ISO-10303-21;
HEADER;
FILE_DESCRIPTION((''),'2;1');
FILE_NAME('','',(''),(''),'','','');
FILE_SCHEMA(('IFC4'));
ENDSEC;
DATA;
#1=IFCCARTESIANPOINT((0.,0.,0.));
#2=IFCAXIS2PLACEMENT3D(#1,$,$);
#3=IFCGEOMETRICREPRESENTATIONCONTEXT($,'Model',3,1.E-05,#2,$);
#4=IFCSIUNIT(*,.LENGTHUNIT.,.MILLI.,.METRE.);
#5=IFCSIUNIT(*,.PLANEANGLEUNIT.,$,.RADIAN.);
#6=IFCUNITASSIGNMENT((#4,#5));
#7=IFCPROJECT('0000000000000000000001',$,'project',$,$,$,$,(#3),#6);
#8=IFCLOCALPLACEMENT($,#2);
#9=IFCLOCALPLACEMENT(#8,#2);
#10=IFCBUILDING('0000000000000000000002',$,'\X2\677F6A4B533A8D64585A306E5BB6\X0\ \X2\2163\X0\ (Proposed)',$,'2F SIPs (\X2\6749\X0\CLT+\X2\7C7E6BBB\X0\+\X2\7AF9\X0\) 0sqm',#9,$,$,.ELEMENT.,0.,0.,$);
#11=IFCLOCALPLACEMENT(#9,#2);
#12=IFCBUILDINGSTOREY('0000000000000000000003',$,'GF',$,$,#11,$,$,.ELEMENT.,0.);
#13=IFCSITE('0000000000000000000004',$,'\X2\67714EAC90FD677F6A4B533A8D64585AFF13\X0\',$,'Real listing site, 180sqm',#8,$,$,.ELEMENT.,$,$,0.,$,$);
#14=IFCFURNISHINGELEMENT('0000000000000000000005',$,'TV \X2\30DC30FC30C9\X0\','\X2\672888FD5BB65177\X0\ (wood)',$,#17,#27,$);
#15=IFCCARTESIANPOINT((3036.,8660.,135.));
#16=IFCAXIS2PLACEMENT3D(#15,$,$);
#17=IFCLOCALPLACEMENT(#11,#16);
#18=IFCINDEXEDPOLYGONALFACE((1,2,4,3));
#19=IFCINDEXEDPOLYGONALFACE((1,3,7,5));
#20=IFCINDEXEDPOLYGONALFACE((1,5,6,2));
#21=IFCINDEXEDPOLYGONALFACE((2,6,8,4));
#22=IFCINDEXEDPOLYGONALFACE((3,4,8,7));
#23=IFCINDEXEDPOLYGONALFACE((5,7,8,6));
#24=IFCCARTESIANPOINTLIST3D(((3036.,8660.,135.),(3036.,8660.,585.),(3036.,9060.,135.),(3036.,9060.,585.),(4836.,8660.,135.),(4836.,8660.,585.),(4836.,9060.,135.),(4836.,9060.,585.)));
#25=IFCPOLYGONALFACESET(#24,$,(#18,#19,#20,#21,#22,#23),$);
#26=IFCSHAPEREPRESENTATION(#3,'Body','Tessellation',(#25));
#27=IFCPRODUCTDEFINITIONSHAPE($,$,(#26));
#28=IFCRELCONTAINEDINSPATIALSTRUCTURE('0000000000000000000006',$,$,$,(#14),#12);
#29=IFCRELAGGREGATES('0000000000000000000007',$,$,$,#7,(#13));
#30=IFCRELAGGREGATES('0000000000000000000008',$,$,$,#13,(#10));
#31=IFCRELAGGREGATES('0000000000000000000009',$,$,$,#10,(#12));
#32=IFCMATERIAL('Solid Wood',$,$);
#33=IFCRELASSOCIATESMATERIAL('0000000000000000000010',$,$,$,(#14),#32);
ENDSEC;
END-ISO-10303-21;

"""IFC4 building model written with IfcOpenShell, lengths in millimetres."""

from ifc_helpers import new_model, si_unit, frame, frame_2d, origin, place, context, project, spatial, rectangle, extrude, material, element, save


model = new_model("IFC4")

# Units and contexts
model_context = context("Model", 3, precision=1e-05, world=origin())
ifc_project = project(units=[si_unit("LENGTHUNIT", "METRE", prefix="MILLI"), si_unit("PLANEANGLEUNIT", "RADIAN")], contexts=[model_context])

# Site, building, storey
site_placement = place(None, origin())
site = spatial("IfcSite", under=ifc_project, at=site_placement, Name="東京都板橋区赤塚３", ObjectType="Real listing site, 180sqm", CompositionType="ELEMENT", RefElevation=0.0)
building_placement = place(site_placement, origin())
building = spatial("IfcBuilding", under=site, at=building_placement, Name="板橋区赤塚の家 Ⅳ (Proposed)", ObjectType="2F SIPs (杉CLT+籾殻+竹) 0sqm", CompositionType="ELEMENT", ElevationOfRefHeight=0.0, ElevationOfTerrain=0.0)
storey_placement = place(building_placement, origin())
storey = spatial("IfcBuildingStorey", under=building, at=storey_placement, Name="GF", CompositionType="ELEMENT", Elevation=0.0)

# Shared definitions
ifc_material_1 = material(Name="Solid Wood")

# Furnishing element
furnishing_placement = place(storey_placement, frame((3036.0, 8660.0, 135.0)))
element("IfcFurnishingElement", 1, at=furnishing_placement, inside=storey, material=ifc_material_1, Name="TV ボード", Description="木製家具 (wood)", context=model_context, shape_type="SweptSolid", body=[
    extrude(rectangle(XDim=1800.0, YDim=400.0, at=frame_2d((900.0, 200.0))), frame((3036.0, 8660.0, 135.0)), (0.0, 0.0, 1.0), 450.0),
])

save(model, "model.ifc")
